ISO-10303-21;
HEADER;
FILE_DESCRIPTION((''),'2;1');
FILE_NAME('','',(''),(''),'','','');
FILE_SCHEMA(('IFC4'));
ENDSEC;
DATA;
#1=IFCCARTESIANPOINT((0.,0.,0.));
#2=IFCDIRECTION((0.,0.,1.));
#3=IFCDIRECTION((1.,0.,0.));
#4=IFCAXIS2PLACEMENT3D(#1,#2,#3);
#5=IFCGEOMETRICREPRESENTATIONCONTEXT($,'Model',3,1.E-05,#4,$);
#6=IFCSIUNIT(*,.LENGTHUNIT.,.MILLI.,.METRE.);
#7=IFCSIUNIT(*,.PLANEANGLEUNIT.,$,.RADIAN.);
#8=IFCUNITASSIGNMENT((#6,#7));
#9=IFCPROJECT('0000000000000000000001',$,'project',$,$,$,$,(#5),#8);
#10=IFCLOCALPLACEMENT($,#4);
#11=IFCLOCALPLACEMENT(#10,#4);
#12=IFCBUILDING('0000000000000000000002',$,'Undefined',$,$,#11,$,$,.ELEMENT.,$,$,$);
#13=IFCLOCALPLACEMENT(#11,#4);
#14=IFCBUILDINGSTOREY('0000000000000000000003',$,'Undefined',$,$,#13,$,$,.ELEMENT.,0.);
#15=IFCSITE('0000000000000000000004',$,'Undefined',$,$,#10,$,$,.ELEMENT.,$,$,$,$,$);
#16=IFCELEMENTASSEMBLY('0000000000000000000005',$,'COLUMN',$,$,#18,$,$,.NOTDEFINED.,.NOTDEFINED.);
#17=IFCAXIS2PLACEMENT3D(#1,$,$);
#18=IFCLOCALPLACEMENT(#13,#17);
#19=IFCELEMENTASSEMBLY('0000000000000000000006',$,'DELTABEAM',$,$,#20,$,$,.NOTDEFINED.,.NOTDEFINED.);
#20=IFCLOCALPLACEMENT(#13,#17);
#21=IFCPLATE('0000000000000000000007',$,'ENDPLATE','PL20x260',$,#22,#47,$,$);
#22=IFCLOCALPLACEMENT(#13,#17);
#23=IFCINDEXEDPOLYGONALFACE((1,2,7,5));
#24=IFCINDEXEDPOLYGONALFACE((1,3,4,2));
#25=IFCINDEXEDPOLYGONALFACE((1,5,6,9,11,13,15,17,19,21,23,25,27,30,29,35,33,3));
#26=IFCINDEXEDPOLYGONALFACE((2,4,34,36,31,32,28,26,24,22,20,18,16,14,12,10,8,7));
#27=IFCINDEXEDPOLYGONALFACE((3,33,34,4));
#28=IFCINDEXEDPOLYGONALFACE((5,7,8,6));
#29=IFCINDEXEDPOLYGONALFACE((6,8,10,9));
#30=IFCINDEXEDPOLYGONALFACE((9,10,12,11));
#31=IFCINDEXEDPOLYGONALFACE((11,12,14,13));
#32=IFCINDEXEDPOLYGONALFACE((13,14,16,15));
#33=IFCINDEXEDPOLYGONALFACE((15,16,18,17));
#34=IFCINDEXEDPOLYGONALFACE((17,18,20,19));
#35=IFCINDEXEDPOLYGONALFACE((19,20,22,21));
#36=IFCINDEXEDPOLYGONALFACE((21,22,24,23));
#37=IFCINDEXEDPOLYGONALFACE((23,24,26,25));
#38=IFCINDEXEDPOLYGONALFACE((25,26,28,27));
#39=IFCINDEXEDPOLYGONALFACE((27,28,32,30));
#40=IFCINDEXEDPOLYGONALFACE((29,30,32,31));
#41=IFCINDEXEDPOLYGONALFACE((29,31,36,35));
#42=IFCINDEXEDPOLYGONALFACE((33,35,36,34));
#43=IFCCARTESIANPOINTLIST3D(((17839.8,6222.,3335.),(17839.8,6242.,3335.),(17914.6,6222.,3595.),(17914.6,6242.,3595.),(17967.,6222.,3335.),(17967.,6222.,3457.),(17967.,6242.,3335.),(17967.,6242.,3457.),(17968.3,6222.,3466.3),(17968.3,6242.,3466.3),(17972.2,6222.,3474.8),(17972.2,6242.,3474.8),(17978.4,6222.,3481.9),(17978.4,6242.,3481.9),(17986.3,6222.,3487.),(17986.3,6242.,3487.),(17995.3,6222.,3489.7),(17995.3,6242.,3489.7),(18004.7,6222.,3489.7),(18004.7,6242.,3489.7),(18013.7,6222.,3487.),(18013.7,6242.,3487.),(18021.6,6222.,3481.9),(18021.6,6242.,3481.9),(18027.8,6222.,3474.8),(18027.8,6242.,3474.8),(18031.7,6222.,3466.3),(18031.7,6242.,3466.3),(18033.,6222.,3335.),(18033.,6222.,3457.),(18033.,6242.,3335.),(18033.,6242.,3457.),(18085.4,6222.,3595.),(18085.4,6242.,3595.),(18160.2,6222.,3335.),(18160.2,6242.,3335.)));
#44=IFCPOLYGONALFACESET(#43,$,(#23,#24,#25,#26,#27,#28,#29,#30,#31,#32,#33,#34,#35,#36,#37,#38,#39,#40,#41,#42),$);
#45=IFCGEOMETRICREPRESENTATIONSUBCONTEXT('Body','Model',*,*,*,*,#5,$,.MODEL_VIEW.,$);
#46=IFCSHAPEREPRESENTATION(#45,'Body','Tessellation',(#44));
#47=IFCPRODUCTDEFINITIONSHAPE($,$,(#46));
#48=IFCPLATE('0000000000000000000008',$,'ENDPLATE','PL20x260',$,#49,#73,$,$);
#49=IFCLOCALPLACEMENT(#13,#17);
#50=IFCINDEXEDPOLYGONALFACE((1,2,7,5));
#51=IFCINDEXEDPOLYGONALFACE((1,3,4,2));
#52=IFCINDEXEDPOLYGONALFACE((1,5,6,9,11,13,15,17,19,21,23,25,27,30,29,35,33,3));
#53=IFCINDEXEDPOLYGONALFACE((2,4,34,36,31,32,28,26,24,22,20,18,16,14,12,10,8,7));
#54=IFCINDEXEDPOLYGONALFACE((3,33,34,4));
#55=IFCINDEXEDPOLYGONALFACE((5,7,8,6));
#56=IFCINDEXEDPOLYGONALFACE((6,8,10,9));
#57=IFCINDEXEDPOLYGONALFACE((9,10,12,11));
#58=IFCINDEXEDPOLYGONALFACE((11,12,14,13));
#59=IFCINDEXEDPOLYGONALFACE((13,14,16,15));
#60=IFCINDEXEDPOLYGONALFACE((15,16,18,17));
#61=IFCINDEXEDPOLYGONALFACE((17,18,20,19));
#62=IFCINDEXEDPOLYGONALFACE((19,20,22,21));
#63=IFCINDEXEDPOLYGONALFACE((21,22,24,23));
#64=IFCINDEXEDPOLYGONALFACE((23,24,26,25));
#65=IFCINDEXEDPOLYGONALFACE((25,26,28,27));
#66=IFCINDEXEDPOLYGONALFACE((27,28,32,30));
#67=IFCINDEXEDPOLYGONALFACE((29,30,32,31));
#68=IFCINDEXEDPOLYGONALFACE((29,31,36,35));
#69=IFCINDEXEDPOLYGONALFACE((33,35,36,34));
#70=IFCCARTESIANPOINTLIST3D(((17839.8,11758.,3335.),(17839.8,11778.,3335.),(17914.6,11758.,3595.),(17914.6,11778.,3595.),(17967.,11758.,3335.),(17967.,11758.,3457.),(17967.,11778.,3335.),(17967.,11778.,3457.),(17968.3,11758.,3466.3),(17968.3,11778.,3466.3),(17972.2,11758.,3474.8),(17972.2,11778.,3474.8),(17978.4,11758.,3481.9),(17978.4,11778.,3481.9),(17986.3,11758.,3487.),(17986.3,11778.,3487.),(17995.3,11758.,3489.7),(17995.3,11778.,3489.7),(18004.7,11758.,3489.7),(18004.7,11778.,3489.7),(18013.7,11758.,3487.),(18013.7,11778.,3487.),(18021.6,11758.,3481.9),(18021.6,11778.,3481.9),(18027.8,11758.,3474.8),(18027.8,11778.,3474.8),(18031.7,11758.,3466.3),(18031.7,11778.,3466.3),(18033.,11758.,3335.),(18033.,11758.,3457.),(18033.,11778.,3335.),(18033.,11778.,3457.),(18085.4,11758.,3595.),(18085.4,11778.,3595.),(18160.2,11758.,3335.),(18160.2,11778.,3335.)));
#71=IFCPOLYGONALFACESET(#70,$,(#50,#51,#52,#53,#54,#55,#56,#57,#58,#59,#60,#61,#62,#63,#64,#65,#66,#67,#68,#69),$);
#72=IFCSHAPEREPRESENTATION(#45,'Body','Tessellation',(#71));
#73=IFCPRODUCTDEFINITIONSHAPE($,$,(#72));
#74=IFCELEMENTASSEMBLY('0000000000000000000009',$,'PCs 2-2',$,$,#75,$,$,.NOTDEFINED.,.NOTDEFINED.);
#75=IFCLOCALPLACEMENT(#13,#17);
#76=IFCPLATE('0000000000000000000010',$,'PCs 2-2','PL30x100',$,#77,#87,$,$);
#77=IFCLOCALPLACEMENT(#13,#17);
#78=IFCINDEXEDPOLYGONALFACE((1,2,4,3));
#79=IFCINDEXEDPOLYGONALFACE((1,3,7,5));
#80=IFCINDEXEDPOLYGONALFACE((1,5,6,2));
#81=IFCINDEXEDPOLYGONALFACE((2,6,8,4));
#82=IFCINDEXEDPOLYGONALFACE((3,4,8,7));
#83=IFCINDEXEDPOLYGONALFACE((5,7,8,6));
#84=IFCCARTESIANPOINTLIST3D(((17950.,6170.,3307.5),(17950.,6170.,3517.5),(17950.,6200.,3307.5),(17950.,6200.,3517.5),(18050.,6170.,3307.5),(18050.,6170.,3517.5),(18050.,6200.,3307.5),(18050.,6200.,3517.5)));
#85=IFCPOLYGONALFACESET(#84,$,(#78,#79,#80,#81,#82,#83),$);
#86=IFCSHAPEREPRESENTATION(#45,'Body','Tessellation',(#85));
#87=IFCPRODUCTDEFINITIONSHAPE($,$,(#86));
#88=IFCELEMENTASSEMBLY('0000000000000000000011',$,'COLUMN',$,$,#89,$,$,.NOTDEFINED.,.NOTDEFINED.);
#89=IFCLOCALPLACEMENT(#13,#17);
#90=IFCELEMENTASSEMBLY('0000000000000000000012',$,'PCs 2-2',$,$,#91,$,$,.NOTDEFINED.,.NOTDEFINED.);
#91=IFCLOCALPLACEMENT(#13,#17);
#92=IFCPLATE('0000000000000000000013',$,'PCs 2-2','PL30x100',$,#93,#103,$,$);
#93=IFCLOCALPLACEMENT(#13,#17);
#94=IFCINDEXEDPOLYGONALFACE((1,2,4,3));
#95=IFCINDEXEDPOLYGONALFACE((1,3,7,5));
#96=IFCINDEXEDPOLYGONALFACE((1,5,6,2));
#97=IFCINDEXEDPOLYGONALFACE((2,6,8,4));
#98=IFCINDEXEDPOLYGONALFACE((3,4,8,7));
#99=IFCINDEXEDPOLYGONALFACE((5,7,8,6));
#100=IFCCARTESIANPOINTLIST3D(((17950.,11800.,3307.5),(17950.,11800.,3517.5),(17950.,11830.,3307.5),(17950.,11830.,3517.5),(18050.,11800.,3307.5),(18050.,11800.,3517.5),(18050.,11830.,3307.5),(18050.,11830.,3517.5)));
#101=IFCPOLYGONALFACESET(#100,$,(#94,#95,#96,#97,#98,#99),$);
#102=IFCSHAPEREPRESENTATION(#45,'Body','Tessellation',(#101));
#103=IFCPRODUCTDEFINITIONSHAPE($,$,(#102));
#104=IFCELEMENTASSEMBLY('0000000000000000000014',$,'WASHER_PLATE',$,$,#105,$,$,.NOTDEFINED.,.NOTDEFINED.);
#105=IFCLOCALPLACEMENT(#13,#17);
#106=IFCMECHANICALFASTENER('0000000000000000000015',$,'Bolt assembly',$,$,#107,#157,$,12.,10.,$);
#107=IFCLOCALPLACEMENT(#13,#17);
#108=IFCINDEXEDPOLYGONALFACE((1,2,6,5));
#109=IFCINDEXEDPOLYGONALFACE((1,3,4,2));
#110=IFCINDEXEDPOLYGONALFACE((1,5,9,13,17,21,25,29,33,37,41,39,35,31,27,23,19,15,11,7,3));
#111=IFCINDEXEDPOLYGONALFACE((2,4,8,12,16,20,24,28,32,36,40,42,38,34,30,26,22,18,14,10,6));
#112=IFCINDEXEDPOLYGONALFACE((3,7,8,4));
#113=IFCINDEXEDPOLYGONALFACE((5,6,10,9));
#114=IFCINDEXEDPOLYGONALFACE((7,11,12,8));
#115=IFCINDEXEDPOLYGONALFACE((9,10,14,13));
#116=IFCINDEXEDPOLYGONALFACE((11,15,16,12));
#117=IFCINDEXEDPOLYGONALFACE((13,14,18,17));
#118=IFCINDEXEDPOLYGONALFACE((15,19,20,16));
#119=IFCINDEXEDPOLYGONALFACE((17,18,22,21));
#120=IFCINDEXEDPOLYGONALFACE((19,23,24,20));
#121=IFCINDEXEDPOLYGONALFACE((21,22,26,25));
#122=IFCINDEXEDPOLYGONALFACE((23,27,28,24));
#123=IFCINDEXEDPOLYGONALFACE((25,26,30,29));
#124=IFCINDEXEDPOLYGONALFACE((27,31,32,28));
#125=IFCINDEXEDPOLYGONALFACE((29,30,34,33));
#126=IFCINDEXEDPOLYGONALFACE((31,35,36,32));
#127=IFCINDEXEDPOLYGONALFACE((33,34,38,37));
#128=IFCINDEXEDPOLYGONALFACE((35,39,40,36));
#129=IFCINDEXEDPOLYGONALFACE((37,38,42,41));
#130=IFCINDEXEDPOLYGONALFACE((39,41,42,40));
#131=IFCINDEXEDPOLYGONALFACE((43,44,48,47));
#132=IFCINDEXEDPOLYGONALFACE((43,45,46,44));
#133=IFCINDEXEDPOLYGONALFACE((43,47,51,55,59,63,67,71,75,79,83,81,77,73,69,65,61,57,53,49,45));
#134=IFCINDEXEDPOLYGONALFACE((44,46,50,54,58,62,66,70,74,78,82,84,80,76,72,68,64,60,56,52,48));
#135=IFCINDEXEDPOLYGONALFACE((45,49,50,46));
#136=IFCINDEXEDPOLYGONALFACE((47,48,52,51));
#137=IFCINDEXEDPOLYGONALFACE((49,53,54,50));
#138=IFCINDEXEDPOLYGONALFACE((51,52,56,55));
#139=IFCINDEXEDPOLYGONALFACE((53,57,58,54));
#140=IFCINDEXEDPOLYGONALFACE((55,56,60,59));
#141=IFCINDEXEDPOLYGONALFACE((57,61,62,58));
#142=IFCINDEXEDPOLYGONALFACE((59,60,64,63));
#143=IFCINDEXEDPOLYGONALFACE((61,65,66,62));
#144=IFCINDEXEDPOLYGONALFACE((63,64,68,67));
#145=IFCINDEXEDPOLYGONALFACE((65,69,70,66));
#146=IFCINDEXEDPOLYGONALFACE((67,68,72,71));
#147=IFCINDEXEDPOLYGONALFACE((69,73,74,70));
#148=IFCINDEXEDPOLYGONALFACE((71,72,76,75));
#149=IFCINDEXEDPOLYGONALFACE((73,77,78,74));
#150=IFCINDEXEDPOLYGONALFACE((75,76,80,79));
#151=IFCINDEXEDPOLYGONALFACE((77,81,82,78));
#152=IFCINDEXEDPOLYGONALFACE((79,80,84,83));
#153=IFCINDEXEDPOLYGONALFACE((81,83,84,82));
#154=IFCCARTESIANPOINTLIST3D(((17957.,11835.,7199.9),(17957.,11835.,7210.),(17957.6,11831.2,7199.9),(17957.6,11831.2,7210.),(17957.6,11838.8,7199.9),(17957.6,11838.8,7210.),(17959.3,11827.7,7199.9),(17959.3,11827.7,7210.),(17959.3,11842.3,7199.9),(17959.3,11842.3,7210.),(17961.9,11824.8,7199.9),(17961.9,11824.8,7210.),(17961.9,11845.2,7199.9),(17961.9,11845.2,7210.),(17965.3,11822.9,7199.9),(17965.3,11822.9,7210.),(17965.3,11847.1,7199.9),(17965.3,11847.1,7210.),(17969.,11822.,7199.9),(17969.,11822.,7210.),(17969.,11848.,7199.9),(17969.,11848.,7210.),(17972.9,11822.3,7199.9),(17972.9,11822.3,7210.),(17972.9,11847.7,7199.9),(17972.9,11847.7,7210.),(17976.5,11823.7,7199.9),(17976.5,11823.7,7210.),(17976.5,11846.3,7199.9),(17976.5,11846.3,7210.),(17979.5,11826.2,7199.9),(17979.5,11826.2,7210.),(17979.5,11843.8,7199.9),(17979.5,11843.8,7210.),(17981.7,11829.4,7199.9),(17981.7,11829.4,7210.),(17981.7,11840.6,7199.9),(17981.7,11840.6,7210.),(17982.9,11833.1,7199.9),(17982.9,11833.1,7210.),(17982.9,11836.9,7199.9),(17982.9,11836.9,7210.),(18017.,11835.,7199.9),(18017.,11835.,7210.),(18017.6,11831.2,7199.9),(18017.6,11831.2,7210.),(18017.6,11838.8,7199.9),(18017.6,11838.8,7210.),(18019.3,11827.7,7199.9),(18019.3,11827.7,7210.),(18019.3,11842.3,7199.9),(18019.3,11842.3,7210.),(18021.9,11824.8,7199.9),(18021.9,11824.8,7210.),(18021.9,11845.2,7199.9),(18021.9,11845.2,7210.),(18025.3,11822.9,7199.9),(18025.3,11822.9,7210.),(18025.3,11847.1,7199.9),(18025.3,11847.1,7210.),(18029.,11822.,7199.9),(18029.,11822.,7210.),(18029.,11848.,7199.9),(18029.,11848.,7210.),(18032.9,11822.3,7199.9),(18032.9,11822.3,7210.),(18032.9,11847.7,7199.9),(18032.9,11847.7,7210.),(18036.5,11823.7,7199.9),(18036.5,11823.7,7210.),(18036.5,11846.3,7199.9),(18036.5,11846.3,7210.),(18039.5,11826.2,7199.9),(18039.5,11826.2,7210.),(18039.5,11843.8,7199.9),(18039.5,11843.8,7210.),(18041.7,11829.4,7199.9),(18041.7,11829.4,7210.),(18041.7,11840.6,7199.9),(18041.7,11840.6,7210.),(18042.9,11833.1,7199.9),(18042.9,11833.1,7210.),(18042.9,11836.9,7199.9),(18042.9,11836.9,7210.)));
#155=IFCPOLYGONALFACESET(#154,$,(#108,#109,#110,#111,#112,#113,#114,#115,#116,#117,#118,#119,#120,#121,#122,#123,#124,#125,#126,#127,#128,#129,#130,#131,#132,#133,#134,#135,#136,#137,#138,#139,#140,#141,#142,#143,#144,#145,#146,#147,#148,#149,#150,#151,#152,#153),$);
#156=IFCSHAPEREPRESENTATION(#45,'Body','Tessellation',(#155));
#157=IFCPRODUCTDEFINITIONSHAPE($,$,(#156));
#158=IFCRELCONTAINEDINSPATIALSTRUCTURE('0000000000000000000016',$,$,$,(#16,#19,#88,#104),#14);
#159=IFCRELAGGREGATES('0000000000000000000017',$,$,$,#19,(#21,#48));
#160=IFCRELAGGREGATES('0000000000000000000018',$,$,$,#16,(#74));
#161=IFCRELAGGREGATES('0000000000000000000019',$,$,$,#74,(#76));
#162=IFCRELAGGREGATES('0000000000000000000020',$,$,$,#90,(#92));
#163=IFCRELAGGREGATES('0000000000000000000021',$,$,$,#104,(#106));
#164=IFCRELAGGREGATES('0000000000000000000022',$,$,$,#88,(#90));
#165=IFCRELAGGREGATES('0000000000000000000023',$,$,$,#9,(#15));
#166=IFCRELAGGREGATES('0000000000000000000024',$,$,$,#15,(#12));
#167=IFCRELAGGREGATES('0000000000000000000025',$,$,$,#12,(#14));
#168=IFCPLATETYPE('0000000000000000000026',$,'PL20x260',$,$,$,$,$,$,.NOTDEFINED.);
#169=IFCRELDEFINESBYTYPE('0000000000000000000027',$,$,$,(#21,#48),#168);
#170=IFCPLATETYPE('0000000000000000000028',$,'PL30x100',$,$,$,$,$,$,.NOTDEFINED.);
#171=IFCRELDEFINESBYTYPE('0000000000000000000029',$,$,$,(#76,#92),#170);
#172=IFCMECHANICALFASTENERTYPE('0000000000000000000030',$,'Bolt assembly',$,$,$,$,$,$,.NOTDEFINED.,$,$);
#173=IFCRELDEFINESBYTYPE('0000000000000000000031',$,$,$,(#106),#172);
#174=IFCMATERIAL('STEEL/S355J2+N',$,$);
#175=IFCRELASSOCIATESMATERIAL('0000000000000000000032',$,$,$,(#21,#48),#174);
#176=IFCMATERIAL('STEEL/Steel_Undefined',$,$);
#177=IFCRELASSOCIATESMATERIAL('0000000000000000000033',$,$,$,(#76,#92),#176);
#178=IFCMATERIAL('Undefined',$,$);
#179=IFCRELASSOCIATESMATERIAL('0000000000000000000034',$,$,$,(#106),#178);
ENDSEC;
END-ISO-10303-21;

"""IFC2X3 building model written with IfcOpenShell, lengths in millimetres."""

from ifc_helpers import new_model, si_unit, frame, frame_2d, origin_with_axes, origin_2d_with_axis, place, context, subcontext, project, spatial, polyline, circle_curve, parameter, trimmed, segment, composite_curve, circle, outline, extrude, source, transform, mapped, material, type_object, element, aggregate, save


model = new_model("IFC2X3")

# Units and contexts
model_context = context("Model", 3, precision=1e-05, world=origin_with_axes())
body_context = subcontext(model_context, "Body", "Model", "MODEL_VIEW")
ifc_project = project(units=[si_unit("LENGTHUNIT", "METRE", prefix="MILLI"), si_unit("PLANEANGLEUNIT", "RADIAN")], contexts=[model_context])

# Site, building, storey
site_placement = place(None, origin_with_axes())
site = spatial("IfcSite", under=ifc_project, at=site_placement, Name="Undefined", CompositionType="ELEMENT")
building_placement = place(site_placement, origin_with_axes())
building = spatial("IfcBuilding", under=site, at=building_placement, Name="Undefined", CompositionType="ELEMENT")
storey_placement = place(building_placement, origin_with_axes())
storey = spatial("IfcBuildingStorey", under=building, at=storey_placement, Name="Undefined", CompositionType="ELEMENT", Elevation=0.0)

# Element assembly
assembly_1_placement = place(storey_placement, origin_with_axes())
assembly_1 = element("IfcElementAssembly", 1, at=assembly_1_placement, inside=storey, Name="COLUMN", AssemblyPlace="NOTDEFINED", PredefinedType="NOTDEFINED")
ifc_material_1 = material(Name="STEEL/Steel_Undefined")

# Element assembly, plates, openings
assembly_2_placement = place(storey_placement, origin_with_axes())
assembly_2 = element("IfcElementAssembly", 2, at=assembly_2_placement, inside=storey, Name="DELTABEAM", AssemblyPlace="NOTDEFINED", PredefinedType="NOTDEFINED")
ifc_material_2 = material(Name="STEEL/S355J2+N")
plate_type_1 = type_object("IfcPlateType", Name="PL20x260", PredefinedType="NOTDEFINED")
plate_1_placement = place(assembly_2_placement, frame((18085.4, 6232.0, 3595.0), z_axis=(0.0, 1.0, 0.0), x_axis=(0.276307, 0.0, -0.961069)))
plate_1 = element("IfcPlate", 3, at=plate_1_placement, type_object=plate_type_1, material=ifc_material_2, Name="ENDPLATE", Description="PL20x260", context=body_context, shape_type="SweptSolid", body=[
    extrude(outline(polyline([(0.0, 0.0), (270.5, 0.0), (182.0, 307.9), (-47.2, 164.2), (0.0, 0.0)])), frame((0.0, 0.0, -10.0), z_axis=(0.0, 0.0, 1.0), x_axis=(1.0, 0.0, 0.0)), (0.0, 0.0, 1.0), 20.0),
])
opening_1_placement = place(assembly_2_placement, frame((18085.4, 6232.0, 3595.0), z_axis=(0.0, 1.0, 0.0), x_axis=(0.276307, 0.0, -0.961069)))
element("IfcOpeningElement", 4, at=opening_1_placement, cuts=plate_1, ObjectType="Recess", context=body_context, shape_type="SweptSolid", body=[
    extrude(outline(composite_curve([segment(trimmed(circle_curve(frame_2d((33.0, 33.0), x_axis=(-1.0, 0.0)), 33.0), [parameter(0.0)], [parameter(1.570796)], True, "PARAMETER"), True, "CONTINUOUS"), segment(polyline([(33.0, 0.0), (156.0, 0.0), (156.0, 66.0), (33.0, 66.0)]), True, "CONTINUOUS"), segment(trimmed(circle_curve(frame_2d((33.0, 33.0), x_axis=(0.0, 1.0)), 33.0), [parameter(0.0)], [parameter(1.570796)], True, "PARAMETER"), True, "CONTINUOUS"), segment(polyline([(0.0, 33.0), (0.0, 33.0)]), True, "CONTINUOUS")], self_intersect=True)), frame((86.4, 79.4, -11.0), z_axis=(0.0, 0.0, 1.0), x_axis=(0.961069, 0.276307, 0.0)), (0.0, 0.0, 1.0), 22.0),
])
plate_2_placement = place(assembly_2_placement, frame((17914.6, 11768.0, 3595.0), z_axis=(0.0, -1.0, 0.0), x_axis=(-0.276307, 0.0, -0.961069)))
plate_2 = element("IfcPlate", 5, at=plate_2_placement, type_object=plate_type_1, material=ifc_material_2, Name="ENDPLATE", Description="PL20x260", context=body_context, shape_type="SweptSolid", body=[
    extrude(outline(polyline([(0.0, 0.0), (270.5, 0.0), (182.0, 307.9), (-47.2, 164.2), (0.0, 0.0)])), frame((0.0, 0.0, -10.0), z_axis=(0.0, 0.0, 1.0), x_axis=(1.0, 0.0, 0.0)), (0.0, 0.0, 1.0), 20.0),
])
opening_2_placement = place(assembly_2_placement, frame((17914.6, 11768.0, 3595.0), z_axis=(0.0, -1.0, 0.0), x_axis=(-0.276307, 0.0, -0.961069)))
element("IfcOpeningElement", 6, at=opening_2_placement, cuts=plate_2, ObjectType="Recess", context=body_context, shape_type="SweptSolid", body=[
    extrude(outline(composite_curve([segment(trimmed(circle_curve(frame_2d((33.0, 33.0), x_axis=(-1.0, 0.0)), 33.0), [parameter(0.0)], [parameter(1.570796)], True, "PARAMETER"), True, "CONTINUOUS"), segment(polyline([(33.0, 0.0), (156.0, 0.0), (156.0, 66.0), (33.0, 66.0)]), True, "CONTINUOUS"), segment(trimmed(circle_curve(frame_2d((33.0, 33.0), x_axis=(0.0, 1.0)), 33.0), [parameter(0.0)], [parameter(1.570796)], True, "PARAMETER"), True, "CONTINUOUS"), segment(polyline([(0.0, 33.0), (0.0, 33.0)]), True, "CONTINUOUS")], self_intersect=True)), frame((86.4, 79.4, -11.0), z_axis=(0.0, 0.0, 1.0), x_axis=(0.961069, 0.276307, 0.0)), (0.0, 0.0, 1.0), 22.0),
])
aggregate(assembly_2, [plate_1, plate_2])

# Element assembly
assembly_3_placement = place(assembly_1_placement, origin_with_axes())
assembly_3 = element("IfcElementAssembly", 7, at=assembly_3_placement, Name="PCs 2-2", AssemblyPlace="NOTDEFINED", PredefinedType="NOTDEFINED")
aggregate(assembly_1, [assembly_3])

# Plate
plate_type_2 = type_object("IfcPlateType", Name="PL30x100", PredefinedType="NOTDEFINED")
plate_3_placement = place(assembly_3_placement, frame((18050.0, 6185.0, 3517.5), z_axis=(0.0, 1.0, 0.0), x_axis=(0.0, 0.0, -1.0)))
plate_3 = element("IfcPlate", 8, at=plate_3_placement, type_object=plate_type_2, material=ifc_material_1, Name="PCs 2-2", Description="PL30x100", context=body_context, shape_type="SweptSolid", body=[
    extrude(outline(polyline([(0.0, 0.0), (210.0, 0.0), (210.0, 100.0), (0.0, 100.0), (0.0, 0.0)])), frame((0.0, 0.0, -15.0), z_axis=(0.0, 0.0, 1.0), x_axis=(1.0, 0.0, 0.0)), (0.0, 0.0, 1.0), 30.0),
])
aggregate(assembly_3, [plate_3])

# Element assemblies, plate
assembly_4_placement = place(storey_placement, origin_with_axes())
assembly_4 = element("IfcElementAssembly", 9, at=assembly_4_placement, inside=storey, Name="COLUMN", AssemblyPlace="NOTDEFINED", PredefinedType="NOTDEFINED")
assembly_5_placement = place(assembly_4_placement, origin_with_axes())
assembly_5 = element("IfcElementAssembly", 10, at=assembly_5_placement, Name="PCs 2-2", AssemblyPlace="NOTDEFINED", PredefinedType="NOTDEFINED")
plate_4_placement = place(assembly_5_placement, frame((17950.0, 11815.0, 3517.5), z_axis=(0.0, -1.0, 0.0), x_axis=(0.0, 0.0, -1.0)))
plate_4 = element("IfcPlate", 11, at=plate_4_placement, type_object=plate_type_2, material=ifc_material_1, Name="PCs 2-2", Description="PL30x100", context=body_context, shape_type="SweptSolid", body=[
    extrude(outline(polyline([(0.0, 0.0), (210.0, 0.0), (210.0, 100.0), (0.0, 100.0), (0.0, 0.0)])), frame((0.0, 0.0, -15.0), z_axis=(0.0, 0.0, 1.0), x_axis=(1.0, 0.0, 0.0)), (0.0, 0.0, 1.0), 30.0),
])
aggregate(assembly_5, [plate_4])

# Element assembly, mechanical fastener
assembly_6_placement = place(storey_placement, origin_with_axes())
assembly_6 = element("IfcElementAssembly", 12, at=assembly_6_placement, inside=storey, Name="WASHER_PLATE", AssemblyPlace="NOTDEFINED", PredefinedType="NOTDEFINED")
ifc_material_3 = material(Name="Undefined")
mechanical_fastener_type = type_object("IfcMechanicalFastenerType", Name="Bolt assembly")
shared_shape_1 = source(origin_with_axes(), body_context, "Body", "SweptSolid", [
    extrude(circle(Radius=13.0, at=origin_2d_with_axis()), frame((0.0, 5.0, 0.0), z_axis=(0.0, 1.0, 0.0), x_axis=(1.0, 0.0, 0.0)), (0.0, 0.0, 1.0), 10.1),
])
mechanical_fastener_1_placement = place(assembly_6_placement, frame((18030.0, 11835.0, 7215.0), z_axis=(0.0, -1.0, 0.0), x_axis=(-1.0, 0.0, 0.0)))
mechanical_fastener_1 = element("IfcMechanicalFastener", 13, at=mechanical_fastener_1_placement, type_object=mechanical_fastener_type, material=ifc_material_3, Name="Bolt assembly", NominalDiameter=12.0, NominalLength=10.0, context=body_context, shape_type="MappedRepresentation", body=[
    mapped(shared_shape_1, transform((0.0, 0.0, 0.0))),
    mapped(shared_shape_1, transform((60.0, 0.0, 0.0))),
])
aggregate(assembly_6, [mechanical_fastener_1])

aggregate(assembly_4, [assembly_5])

save(model, "model.ifc")
